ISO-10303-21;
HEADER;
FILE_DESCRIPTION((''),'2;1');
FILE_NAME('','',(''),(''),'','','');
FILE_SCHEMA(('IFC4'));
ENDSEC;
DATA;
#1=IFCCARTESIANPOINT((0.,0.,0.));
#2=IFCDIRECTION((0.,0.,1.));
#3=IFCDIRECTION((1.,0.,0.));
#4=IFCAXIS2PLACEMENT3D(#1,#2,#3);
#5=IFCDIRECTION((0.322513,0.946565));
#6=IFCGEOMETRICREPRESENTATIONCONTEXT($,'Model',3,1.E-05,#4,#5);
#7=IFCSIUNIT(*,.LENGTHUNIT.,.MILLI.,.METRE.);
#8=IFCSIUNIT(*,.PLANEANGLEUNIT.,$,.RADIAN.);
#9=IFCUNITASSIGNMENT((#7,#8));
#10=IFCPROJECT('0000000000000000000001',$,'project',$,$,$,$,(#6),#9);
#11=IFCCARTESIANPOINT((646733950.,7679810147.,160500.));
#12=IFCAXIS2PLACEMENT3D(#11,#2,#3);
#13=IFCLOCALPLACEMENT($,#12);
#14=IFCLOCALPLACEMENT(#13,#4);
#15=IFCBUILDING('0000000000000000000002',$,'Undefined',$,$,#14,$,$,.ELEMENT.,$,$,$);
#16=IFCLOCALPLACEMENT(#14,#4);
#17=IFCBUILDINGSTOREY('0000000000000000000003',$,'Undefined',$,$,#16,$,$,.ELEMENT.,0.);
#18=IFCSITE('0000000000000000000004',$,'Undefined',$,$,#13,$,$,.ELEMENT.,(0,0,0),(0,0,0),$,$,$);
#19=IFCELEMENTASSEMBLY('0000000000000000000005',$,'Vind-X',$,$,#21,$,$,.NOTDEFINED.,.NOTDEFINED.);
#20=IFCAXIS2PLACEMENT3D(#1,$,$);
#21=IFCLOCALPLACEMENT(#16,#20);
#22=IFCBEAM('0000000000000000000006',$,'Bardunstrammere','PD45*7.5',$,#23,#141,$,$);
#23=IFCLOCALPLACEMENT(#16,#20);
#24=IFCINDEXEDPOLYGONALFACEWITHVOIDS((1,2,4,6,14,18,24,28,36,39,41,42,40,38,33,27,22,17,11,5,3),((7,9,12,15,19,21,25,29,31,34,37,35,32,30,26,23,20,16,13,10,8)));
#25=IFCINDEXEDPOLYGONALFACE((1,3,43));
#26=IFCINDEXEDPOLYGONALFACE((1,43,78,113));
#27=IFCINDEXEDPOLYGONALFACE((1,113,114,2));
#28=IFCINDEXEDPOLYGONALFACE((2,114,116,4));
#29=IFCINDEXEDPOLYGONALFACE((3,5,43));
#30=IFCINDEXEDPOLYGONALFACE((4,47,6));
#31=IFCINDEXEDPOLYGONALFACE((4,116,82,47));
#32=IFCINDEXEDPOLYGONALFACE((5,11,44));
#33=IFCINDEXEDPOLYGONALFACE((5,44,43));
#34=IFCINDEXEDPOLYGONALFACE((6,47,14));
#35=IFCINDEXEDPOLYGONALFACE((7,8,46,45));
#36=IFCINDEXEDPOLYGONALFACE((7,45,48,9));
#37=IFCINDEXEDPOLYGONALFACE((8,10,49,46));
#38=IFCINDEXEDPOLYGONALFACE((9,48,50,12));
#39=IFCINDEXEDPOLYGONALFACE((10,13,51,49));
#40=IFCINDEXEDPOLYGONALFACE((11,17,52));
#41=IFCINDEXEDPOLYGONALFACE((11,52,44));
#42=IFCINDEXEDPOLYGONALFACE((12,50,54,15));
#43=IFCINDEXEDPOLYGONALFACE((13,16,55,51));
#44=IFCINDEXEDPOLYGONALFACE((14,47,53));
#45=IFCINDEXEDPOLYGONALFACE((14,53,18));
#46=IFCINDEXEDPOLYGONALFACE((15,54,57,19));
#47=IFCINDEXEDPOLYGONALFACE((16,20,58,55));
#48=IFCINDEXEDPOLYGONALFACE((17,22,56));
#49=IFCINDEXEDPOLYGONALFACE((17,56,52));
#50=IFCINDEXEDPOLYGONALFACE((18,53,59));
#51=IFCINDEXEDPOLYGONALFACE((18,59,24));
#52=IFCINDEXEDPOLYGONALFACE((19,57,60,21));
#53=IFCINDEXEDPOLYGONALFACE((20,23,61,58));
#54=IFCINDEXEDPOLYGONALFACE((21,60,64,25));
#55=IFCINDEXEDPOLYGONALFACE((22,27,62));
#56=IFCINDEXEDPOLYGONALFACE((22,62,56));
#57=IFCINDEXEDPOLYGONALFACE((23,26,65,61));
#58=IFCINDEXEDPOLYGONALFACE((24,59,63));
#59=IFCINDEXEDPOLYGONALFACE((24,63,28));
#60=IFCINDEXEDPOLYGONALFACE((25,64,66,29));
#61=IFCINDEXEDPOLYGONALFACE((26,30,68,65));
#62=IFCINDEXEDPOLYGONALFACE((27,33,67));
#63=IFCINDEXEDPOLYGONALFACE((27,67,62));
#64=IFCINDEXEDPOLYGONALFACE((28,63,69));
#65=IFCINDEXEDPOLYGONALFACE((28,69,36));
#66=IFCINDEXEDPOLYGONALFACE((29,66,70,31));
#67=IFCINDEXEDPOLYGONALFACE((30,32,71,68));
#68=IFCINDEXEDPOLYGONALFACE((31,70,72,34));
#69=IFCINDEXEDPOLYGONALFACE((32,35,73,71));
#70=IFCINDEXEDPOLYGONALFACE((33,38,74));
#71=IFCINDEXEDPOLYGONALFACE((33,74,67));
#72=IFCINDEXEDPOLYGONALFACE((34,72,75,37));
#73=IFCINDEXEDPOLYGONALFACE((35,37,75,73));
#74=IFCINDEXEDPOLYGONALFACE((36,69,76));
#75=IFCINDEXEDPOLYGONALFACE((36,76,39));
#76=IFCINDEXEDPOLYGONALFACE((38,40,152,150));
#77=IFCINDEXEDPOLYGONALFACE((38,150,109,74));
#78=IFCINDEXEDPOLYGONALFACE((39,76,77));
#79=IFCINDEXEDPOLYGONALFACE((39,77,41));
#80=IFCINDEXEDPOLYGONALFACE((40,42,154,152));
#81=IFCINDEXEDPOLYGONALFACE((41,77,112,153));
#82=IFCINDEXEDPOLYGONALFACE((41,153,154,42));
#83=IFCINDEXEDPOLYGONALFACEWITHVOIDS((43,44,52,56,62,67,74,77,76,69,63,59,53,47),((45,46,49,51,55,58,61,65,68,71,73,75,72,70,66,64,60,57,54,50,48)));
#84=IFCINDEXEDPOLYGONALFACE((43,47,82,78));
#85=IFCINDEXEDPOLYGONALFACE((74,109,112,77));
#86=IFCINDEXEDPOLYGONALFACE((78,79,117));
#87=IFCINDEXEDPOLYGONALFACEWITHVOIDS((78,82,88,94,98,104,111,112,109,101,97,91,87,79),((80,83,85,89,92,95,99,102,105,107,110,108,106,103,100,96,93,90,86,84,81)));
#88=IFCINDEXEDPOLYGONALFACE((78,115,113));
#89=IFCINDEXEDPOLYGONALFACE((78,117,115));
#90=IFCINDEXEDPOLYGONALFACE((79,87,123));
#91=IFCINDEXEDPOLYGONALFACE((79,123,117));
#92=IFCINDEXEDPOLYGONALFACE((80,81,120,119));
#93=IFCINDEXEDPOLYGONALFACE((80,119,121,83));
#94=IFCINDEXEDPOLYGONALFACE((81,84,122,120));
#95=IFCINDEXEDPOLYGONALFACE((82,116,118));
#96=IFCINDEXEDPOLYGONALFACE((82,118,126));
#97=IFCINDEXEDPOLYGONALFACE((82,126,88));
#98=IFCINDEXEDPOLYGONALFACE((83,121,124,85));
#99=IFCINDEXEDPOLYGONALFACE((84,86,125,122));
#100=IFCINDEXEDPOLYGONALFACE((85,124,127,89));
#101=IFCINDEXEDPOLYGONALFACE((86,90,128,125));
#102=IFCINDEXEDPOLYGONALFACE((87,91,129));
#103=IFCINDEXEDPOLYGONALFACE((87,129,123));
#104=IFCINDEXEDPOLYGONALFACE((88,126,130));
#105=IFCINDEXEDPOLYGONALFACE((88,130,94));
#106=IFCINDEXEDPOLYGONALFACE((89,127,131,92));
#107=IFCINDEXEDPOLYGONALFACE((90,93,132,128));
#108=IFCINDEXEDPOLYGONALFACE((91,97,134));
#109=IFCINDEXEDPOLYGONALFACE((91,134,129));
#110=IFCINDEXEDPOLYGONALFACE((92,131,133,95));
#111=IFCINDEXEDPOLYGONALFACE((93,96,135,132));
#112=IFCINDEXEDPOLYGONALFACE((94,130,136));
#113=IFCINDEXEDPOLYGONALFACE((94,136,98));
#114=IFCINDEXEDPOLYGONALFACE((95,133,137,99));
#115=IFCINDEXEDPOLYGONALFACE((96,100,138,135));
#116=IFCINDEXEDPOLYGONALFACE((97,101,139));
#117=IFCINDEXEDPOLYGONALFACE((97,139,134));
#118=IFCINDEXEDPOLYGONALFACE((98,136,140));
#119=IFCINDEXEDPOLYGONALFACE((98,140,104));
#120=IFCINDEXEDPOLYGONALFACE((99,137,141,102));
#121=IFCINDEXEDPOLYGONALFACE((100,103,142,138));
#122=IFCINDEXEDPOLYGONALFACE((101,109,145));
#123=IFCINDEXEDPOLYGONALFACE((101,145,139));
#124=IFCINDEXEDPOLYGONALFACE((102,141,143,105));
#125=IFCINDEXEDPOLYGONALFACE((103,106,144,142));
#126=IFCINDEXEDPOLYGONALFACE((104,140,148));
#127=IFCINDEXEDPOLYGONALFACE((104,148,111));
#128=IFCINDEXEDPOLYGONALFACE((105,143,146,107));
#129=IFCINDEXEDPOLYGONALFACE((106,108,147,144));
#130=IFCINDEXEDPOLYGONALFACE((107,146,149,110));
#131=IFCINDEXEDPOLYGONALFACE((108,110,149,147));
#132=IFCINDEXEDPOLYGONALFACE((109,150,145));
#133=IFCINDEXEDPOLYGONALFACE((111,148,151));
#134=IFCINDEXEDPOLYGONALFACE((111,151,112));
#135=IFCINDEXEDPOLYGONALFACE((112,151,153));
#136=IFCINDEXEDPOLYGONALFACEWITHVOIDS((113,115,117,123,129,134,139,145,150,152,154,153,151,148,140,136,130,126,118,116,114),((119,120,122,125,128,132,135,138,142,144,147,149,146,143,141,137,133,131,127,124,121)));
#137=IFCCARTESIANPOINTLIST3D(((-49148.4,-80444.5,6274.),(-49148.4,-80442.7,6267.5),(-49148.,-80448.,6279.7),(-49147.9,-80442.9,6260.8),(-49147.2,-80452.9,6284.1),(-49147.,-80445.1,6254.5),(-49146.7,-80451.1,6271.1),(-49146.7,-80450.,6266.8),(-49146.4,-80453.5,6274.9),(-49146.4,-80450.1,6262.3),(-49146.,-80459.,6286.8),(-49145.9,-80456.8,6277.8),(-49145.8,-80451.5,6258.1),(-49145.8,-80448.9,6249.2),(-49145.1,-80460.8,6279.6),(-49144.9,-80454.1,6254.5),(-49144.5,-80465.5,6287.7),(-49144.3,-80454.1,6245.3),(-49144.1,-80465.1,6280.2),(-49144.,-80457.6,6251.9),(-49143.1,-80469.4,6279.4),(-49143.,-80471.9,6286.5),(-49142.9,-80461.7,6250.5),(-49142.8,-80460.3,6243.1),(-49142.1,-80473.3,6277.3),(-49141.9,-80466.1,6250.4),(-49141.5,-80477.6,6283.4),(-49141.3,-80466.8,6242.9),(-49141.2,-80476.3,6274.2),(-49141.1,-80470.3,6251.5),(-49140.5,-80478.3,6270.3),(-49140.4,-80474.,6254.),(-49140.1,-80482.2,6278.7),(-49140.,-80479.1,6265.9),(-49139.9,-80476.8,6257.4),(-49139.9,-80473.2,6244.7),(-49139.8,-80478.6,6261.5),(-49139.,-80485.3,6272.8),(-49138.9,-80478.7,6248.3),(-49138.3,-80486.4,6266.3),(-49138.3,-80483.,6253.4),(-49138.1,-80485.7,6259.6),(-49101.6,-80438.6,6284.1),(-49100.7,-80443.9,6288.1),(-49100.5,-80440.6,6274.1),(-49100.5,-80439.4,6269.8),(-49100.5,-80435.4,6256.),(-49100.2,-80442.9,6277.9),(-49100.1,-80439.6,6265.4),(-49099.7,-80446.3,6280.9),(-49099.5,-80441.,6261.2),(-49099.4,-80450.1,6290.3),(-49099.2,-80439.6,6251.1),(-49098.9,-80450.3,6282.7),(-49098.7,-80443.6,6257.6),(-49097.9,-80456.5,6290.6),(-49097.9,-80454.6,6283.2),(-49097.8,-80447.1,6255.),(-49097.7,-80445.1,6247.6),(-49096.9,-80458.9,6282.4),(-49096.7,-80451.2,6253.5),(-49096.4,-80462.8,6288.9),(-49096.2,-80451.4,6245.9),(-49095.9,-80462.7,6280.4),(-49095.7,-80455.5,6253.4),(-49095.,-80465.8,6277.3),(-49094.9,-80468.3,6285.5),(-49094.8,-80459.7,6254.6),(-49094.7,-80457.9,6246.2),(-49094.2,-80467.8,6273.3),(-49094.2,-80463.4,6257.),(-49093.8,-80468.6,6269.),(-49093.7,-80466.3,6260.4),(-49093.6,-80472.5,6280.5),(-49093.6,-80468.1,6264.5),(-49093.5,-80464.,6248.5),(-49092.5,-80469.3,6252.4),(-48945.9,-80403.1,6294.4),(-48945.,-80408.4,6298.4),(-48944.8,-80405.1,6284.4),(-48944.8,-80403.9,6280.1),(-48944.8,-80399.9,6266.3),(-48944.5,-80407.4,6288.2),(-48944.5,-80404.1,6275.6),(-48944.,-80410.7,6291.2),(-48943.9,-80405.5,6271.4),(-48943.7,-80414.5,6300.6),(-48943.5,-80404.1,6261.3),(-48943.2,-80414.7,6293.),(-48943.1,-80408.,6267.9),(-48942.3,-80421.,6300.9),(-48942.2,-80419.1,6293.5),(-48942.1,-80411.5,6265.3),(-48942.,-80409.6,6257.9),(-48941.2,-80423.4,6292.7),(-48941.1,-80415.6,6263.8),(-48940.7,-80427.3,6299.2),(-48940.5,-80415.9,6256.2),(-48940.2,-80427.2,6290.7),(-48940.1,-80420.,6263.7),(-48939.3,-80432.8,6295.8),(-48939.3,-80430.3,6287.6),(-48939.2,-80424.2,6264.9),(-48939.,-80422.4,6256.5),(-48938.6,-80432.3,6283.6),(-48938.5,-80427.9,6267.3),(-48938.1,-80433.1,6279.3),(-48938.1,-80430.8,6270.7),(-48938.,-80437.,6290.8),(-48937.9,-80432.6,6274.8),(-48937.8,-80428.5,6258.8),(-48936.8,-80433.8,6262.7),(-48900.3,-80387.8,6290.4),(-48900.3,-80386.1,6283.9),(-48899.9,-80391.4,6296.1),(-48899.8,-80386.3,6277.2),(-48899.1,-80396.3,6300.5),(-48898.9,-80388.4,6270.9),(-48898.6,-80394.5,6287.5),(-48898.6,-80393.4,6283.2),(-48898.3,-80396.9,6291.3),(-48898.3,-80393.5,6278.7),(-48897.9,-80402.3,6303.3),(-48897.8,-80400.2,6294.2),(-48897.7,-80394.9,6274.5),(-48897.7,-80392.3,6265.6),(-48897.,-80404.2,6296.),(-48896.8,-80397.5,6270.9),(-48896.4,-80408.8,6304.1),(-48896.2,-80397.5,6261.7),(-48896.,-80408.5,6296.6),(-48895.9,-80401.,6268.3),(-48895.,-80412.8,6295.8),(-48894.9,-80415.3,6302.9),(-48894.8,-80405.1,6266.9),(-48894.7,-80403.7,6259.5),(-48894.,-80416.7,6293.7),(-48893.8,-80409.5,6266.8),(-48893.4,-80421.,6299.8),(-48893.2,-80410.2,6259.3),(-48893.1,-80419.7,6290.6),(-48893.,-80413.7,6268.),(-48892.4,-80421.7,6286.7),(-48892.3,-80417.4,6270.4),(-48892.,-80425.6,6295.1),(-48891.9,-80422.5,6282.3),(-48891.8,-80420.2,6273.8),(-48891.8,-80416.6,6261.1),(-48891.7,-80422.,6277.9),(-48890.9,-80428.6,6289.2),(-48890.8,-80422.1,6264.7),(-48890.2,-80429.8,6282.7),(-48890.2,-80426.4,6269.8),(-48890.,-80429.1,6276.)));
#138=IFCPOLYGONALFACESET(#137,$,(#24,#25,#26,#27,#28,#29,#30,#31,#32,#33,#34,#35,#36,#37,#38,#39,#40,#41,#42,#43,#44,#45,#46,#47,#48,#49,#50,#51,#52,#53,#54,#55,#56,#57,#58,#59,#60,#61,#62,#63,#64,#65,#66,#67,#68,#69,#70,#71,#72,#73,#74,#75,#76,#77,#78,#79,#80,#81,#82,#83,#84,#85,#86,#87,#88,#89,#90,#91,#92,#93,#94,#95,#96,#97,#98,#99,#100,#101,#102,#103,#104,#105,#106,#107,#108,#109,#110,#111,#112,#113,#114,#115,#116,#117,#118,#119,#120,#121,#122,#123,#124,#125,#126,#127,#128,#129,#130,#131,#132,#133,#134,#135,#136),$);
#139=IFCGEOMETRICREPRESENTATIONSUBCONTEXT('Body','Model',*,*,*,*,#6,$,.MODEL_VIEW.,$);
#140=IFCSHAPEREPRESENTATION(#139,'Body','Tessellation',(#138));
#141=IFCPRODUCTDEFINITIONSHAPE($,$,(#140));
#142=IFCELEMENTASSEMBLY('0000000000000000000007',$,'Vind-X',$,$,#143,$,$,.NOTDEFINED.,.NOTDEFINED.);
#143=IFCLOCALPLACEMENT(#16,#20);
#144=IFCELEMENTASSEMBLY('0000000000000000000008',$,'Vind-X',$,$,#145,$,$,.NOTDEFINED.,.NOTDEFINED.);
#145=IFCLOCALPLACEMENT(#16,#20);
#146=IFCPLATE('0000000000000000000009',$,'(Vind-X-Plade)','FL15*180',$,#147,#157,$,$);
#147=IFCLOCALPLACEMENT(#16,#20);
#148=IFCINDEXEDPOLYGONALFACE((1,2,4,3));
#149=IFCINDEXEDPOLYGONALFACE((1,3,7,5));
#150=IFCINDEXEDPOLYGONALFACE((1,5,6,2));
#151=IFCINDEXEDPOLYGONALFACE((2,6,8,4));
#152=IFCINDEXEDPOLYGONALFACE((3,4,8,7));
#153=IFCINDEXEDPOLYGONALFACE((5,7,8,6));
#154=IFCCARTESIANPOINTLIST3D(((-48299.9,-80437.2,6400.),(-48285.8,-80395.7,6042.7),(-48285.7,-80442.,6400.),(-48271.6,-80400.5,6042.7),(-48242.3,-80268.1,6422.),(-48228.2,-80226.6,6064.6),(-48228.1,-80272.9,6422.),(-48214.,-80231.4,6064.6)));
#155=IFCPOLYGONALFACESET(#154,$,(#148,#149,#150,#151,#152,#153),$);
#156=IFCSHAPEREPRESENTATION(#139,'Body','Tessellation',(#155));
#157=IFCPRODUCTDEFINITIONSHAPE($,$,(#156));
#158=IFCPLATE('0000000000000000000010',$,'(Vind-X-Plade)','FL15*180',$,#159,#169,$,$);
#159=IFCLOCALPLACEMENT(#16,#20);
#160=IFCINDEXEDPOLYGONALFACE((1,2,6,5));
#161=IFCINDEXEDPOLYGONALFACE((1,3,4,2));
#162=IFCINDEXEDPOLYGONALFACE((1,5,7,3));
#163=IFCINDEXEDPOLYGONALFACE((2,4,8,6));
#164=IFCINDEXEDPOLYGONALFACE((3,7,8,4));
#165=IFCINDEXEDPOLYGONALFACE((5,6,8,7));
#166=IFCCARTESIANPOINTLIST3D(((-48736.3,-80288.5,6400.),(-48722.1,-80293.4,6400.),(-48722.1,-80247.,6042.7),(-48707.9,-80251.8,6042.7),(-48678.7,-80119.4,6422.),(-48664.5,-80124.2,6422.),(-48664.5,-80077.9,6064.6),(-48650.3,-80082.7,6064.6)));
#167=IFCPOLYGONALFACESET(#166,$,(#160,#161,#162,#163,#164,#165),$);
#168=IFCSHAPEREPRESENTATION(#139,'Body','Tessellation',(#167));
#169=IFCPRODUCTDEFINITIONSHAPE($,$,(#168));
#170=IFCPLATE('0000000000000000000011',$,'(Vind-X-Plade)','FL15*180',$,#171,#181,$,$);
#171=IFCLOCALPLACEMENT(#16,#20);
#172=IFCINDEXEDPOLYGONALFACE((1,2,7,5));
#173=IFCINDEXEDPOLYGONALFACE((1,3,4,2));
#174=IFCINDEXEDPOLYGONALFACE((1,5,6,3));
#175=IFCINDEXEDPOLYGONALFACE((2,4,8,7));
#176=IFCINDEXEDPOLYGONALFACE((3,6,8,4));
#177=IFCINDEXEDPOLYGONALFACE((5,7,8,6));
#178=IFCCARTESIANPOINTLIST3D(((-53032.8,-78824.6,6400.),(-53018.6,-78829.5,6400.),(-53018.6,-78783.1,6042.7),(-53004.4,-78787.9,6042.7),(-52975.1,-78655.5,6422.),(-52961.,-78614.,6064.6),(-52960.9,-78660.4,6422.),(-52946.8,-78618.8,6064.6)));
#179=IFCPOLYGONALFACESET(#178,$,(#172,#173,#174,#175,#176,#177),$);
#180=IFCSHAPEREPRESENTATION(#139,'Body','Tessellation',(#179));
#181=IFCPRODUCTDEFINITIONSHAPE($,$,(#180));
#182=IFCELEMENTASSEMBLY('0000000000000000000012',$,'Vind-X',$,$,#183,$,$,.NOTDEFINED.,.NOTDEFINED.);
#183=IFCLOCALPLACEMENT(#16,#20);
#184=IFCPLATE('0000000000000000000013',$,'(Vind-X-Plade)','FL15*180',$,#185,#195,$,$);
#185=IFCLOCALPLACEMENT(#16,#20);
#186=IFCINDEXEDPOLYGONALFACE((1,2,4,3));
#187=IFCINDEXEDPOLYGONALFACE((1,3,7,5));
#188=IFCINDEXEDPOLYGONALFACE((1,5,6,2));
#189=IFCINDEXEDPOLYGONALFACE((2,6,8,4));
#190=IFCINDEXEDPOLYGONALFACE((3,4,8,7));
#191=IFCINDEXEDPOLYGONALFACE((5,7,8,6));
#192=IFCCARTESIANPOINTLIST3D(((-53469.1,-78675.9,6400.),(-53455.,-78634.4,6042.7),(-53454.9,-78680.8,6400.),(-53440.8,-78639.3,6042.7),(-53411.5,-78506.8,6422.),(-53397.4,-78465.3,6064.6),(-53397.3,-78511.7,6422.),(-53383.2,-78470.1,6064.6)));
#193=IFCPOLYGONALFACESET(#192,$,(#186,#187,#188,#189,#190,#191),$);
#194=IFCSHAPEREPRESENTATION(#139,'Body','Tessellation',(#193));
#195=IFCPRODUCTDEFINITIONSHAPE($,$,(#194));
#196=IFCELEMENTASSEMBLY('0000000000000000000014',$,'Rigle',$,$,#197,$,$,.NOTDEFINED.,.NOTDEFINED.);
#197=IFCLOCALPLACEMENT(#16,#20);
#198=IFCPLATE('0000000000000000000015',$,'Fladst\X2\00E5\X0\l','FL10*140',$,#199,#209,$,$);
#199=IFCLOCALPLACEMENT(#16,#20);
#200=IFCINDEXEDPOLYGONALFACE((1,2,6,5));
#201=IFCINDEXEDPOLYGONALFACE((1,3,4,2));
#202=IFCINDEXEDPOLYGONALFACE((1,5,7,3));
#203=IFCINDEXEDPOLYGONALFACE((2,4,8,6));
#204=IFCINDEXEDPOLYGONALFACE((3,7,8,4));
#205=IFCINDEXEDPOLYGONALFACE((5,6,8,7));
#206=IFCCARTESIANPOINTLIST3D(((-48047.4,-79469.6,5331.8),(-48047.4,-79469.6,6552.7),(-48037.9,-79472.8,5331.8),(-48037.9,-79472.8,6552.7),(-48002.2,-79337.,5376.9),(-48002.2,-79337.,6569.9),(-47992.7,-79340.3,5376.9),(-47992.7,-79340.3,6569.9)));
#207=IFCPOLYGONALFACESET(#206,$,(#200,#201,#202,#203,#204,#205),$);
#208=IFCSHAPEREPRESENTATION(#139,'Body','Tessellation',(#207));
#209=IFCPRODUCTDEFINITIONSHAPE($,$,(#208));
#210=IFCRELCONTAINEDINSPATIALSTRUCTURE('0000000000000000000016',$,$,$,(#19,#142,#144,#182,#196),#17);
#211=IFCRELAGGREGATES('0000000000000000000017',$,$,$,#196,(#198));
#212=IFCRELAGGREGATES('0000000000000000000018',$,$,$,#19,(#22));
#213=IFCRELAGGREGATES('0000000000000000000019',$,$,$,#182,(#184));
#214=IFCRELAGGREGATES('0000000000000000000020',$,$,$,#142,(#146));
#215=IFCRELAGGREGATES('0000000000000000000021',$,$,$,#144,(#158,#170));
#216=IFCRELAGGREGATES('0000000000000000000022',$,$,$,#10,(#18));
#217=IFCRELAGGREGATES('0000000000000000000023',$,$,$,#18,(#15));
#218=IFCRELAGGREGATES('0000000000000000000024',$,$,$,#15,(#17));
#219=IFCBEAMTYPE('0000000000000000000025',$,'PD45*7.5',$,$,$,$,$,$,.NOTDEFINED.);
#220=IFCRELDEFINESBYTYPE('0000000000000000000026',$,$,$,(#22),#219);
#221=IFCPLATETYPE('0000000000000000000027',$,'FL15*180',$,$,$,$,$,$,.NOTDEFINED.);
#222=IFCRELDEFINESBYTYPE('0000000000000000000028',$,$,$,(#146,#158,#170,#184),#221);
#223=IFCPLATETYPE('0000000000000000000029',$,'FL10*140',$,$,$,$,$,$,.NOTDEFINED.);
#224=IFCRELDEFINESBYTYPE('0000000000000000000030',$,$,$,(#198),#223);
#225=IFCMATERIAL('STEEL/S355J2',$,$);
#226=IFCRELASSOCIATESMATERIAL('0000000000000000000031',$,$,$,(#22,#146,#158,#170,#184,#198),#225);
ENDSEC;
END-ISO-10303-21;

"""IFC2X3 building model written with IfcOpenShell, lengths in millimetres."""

from ifc_helpers import new_model, si_unit, direction, frame, origin_with_axes, origin_2d_with_axis, place, context, subcontext, project, spatial, polyline, rectangle, hollow_circle, outline, extrude, boolean, material, type_object, element, aggregate, save


model = new_model("IFC2X3")

# Units and contexts
model_context = context("Model", 3, precision=1e-05, world=origin_with_axes(), true_north=direction((0.322513, 0.946565)))
body_context = subcontext(model_context, "Body", "Model", "MODEL_VIEW")
ifc_project = project(units=[si_unit("LENGTHUNIT", "METRE", prefix="MILLI"), si_unit("PLANEANGLEUNIT", "RADIAN")], contexts=[model_context])

# Site, building, storey
site_placement = place(None, frame((646733950.0, 7679810147.0, 160500.0), z_axis=(0.0, 0.0, 1.0), x_axis=(1.0, 0.0, 0.0)))
site = spatial("IfcSite", under=ifc_project, at=site_placement, Name="Undefined", CompositionType="ELEMENT", RefLatitude=(0, 0, 0), RefLongitude=(0, 0, 0))
building_placement = place(site_placement, origin_with_axes())
building = spatial("IfcBuilding", under=site, at=building_placement, Name="Undefined", CompositionType="ELEMENT")
storey_placement = place(building_placement, origin_with_axes())
storey = spatial("IfcBuildingStorey", under=building, at=storey_placement, Name="Undefined", CompositionType="ELEMENT", Elevation=0.0)

# Element assembly, beam
assembly_1_placement = place(storey_placement, origin_with_axes())
assembly_1 = element("IfcElementAssembly", 1, at=assembly_1_placement, inside=storey, Name="Vind-X", AssemblyPlace="NOTDEFINED", PredefinedType="NOTDEFINED")
ifc_material_1 = material(Name="STEEL/S355J2")
beam_type_1 = type_object("IfcBeamType", Name="PD45*7.5", PredefinedType="NOTDEFINED")
beam_1_placement = place(assembly_1_placement, frame((-49143.3, -80464.5, 6265.2), z_axis=(0.039482, 0.1146, -0.992627), x_axis=(0.972923, 0.221999, 0.064329)))
beam_1 = element("IfcBeam", 2, at=beam_1_placement, type_object=beam_type_1, material=ifc_material_1, Name="Bardunstrammere", Description="PD45*7.5", context=body_context, shape_type="CSG", body=[
    boolean("DIFFERENCE", extrude(hollow_circle(Radius=22.5, WallThickness=7.5, at=origin_2d_with_axis()), frame((255.0, 0.0, 0.0), z_axis=(-1.0, 0.0, 0.0), x_axis=(0.0, -1.0, 0.0)), (0.0, 0.0, 1.0), 255.0), extrude(rectangle(XDim=35.0, YDim=90.0, at=origin_2d_with_axis()), frame((207.5, 0.0, 0.0), z_axis=(-1.0, 0.0, 0.0), x_axis=(0.0, -1.0, 0.0)), (0.0, 0.0, 1.0), 160.0)),
])

# Element assemblies
assembly_2_placement = place(storey_placement, origin_with_axes())
assembly_2 = element("IfcElementAssembly", 3, at=assembly_2_placement, inside=storey, Name="Vind-X", AssemblyPlace="NOTDEFINED", PredefinedType="NOTDEFINED")
assembly_3_placement = place(storey_placement, origin_with_axes())
assembly_3 = element("IfcElementAssembly", 4, at=assembly_3_placement, inside=storey, Name="Vind-X", AssemblyPlace="NOTDEFINED", PredefinedType="NOTDEFINED")

# Plates
plate_type_1 = type_object("IfcPlateType", Name="FL15*180", PredefinedType="NOTDEFINED")
plate_1_placement = place(assembly_2_placement, frame((-48292.8, -80439.6, 6400.0), z_axis=(-0.946565, 0.322513, 0.0), x_axis=(0.320109, 0.93951, 0.121869)))
plate_1 = element("IfcPlate", 5, at=plate_1_placement, type_object=plate_type_1, material=ifc_material_1, Name="(Vind-X-Plade)", Description="FL15*180", context=body_context, shape_type="SweptSolid", body=[
    extrude(outline(polyline([(0.0, 0.0), (180.0, 0.0), (180.0, 360.0), (0.0, 360.0), (0.0, 0.0)])), frame((0.0, 0.0, -7.5), z_axis=(0.0, 0.0, 1.0), x_axis=(1.0, 0.0, 0.0)), (0.0, 0.0, 1.0), 15.0),
])
plate_2_placement = place(assembly_3_placement, frame((-48671.6, -80121.8, 6422.0), z_axis=(0.946565, -0.322513, 0.0), x_axis=(-0.320109, -0.93951, -0.121869)))
plate_2 = element("IfcPlate", 6, at=plate_2_placement, type_object=plate_type_1, material=ifc_material_1, Name="(Vind-X-Plade)", Description="FL15*180", context=body_context, shape_type="SweptSolid", body=[
    extrude(outline(polyline([(0.0, 0.0), (180.0, 0.0), (180.0, 360.0), (0.0, 360.0), (0.0, 0.0)])), frame((0.0, 0.0, -7.5), z_axis=(0.0, 0.0, 1.0), x_axis=(1.0, 0.0, 0.0)), (0.0, 0.0, 1.0), 15.0),
])
plate_3_placement = place(assembly_3_placement, frame((-53025.7, -78827.0, 6400.0), z_axis=(-0.946565, 0.322513, 0.0), x_axis=(0.320109, 0.93951, 0.121869)))
plate_3 = element("IfcPlate", 7, at=plate_3_placement, type_object=plate_type_1, material=ifc_material_1, Name="(Vind-X-Plade)", Description="FL15*180", context=body_context, shape_type="SweptSolid", body=[
    extrude(outline(polyline([(0.0, 0.0), (180.0, 0.0), (180.0, 360.0), (0.0, 360.0), (0.0, 0.0)])), frame((0.0, 0.0, -7.5), z_axis=(0.0, 0.0, 1.0), x_axis=(1.0, 0.0, 0.0)), (0.0, 0.0, 1.0), 15.0),
])

# Element assemblies, plates
assembly_4_placement = place(storey_placement, origin_with_axes())
assembly_4 = element("IfcElementAssembly", 8, at=assembly_4_placement, inside=storey, Name="Vind-X", AssemblyPlace="NOTDEFINED", PredefinedType="NOTDEFINED")
plate_4_placement = place(assembly_4_placement, frame((-53404.4, -78509.3, 6422.0), z_axis=(0.946565, -0.322513, 0.0), x_axis=(-0.320109, -0.93951, -0.121869)))
plate_4 = element("IfcPlate", 9, at=plate_4_placement, type_object=plate_type_1, material=ifc_material_1, Name="(Vind-X-Plade)", Description="FL15*180", context=body_context, shape_type="SweptSolid", body=[
    extrude(outline(polyline([(0.0, 0.0), (180.0, 0.0), (180.0, 360.0), (0.0, 360.0), (0.0, 0.0)])), frame((0.0, 0.0, -7.5), z_axis=(0.0, 0.0, 1.0), x_axis=(1.0, 0.0, 0.0)), (0.0, 0.0, 1.0), 15.0),
])
assembly_5_placement = place(storey_placement, origin_with_axes())
assembly_5 = element("IfcElementAssembly", 10, at=assembly_5_placement, inside=storey, Name="Rigle", AssemblyPlace="NOTDEFINED", PredefinedType="NOTDEFINED")
plate_type_2 = type_object("IfcPlateType", Name="FL10*140", PredefinedType="NOTDEFINED")
plate_5_placement = place(assembly_5_placement, frame((-48042.6, -79471.2, 6552.7), z_axis=(-0.946565, 0.322513, 0.0), x_axis=(0.320109, 0.93951, 0.121869)))
plate_5 = element("IfcPlate", 11, at=plate_5_placement, type_object=plate_type_2, material=ifc_material_1, Name="Fladstål", Description="FL10*140", context=body_context, shape_type="SweptSolid", body=[
    extrude(outline(polyline([(0.0, 0.0), (141.1, 0.0), (-4.3, 1184.1), (-148.8, 1211.8), (0.0, 0.0)])), frame((0.0, 0.0, -5.0), z_axis=(0.0, 0.0, 1.0), x_axis=(1.0, 0.0, 0.0)), (0.0, 0.0, 1.0), 10.0),
])

aggregate(assembly_5, [plate_5])
aggregate(assembly_1, [beam_1])
aggregate(assembly_4, [plate_4])
aggregate(assembly_2, [plate_1])
aggregate(assembly_3, [plate_2, plate_3])

save(model, "model.ifc")
